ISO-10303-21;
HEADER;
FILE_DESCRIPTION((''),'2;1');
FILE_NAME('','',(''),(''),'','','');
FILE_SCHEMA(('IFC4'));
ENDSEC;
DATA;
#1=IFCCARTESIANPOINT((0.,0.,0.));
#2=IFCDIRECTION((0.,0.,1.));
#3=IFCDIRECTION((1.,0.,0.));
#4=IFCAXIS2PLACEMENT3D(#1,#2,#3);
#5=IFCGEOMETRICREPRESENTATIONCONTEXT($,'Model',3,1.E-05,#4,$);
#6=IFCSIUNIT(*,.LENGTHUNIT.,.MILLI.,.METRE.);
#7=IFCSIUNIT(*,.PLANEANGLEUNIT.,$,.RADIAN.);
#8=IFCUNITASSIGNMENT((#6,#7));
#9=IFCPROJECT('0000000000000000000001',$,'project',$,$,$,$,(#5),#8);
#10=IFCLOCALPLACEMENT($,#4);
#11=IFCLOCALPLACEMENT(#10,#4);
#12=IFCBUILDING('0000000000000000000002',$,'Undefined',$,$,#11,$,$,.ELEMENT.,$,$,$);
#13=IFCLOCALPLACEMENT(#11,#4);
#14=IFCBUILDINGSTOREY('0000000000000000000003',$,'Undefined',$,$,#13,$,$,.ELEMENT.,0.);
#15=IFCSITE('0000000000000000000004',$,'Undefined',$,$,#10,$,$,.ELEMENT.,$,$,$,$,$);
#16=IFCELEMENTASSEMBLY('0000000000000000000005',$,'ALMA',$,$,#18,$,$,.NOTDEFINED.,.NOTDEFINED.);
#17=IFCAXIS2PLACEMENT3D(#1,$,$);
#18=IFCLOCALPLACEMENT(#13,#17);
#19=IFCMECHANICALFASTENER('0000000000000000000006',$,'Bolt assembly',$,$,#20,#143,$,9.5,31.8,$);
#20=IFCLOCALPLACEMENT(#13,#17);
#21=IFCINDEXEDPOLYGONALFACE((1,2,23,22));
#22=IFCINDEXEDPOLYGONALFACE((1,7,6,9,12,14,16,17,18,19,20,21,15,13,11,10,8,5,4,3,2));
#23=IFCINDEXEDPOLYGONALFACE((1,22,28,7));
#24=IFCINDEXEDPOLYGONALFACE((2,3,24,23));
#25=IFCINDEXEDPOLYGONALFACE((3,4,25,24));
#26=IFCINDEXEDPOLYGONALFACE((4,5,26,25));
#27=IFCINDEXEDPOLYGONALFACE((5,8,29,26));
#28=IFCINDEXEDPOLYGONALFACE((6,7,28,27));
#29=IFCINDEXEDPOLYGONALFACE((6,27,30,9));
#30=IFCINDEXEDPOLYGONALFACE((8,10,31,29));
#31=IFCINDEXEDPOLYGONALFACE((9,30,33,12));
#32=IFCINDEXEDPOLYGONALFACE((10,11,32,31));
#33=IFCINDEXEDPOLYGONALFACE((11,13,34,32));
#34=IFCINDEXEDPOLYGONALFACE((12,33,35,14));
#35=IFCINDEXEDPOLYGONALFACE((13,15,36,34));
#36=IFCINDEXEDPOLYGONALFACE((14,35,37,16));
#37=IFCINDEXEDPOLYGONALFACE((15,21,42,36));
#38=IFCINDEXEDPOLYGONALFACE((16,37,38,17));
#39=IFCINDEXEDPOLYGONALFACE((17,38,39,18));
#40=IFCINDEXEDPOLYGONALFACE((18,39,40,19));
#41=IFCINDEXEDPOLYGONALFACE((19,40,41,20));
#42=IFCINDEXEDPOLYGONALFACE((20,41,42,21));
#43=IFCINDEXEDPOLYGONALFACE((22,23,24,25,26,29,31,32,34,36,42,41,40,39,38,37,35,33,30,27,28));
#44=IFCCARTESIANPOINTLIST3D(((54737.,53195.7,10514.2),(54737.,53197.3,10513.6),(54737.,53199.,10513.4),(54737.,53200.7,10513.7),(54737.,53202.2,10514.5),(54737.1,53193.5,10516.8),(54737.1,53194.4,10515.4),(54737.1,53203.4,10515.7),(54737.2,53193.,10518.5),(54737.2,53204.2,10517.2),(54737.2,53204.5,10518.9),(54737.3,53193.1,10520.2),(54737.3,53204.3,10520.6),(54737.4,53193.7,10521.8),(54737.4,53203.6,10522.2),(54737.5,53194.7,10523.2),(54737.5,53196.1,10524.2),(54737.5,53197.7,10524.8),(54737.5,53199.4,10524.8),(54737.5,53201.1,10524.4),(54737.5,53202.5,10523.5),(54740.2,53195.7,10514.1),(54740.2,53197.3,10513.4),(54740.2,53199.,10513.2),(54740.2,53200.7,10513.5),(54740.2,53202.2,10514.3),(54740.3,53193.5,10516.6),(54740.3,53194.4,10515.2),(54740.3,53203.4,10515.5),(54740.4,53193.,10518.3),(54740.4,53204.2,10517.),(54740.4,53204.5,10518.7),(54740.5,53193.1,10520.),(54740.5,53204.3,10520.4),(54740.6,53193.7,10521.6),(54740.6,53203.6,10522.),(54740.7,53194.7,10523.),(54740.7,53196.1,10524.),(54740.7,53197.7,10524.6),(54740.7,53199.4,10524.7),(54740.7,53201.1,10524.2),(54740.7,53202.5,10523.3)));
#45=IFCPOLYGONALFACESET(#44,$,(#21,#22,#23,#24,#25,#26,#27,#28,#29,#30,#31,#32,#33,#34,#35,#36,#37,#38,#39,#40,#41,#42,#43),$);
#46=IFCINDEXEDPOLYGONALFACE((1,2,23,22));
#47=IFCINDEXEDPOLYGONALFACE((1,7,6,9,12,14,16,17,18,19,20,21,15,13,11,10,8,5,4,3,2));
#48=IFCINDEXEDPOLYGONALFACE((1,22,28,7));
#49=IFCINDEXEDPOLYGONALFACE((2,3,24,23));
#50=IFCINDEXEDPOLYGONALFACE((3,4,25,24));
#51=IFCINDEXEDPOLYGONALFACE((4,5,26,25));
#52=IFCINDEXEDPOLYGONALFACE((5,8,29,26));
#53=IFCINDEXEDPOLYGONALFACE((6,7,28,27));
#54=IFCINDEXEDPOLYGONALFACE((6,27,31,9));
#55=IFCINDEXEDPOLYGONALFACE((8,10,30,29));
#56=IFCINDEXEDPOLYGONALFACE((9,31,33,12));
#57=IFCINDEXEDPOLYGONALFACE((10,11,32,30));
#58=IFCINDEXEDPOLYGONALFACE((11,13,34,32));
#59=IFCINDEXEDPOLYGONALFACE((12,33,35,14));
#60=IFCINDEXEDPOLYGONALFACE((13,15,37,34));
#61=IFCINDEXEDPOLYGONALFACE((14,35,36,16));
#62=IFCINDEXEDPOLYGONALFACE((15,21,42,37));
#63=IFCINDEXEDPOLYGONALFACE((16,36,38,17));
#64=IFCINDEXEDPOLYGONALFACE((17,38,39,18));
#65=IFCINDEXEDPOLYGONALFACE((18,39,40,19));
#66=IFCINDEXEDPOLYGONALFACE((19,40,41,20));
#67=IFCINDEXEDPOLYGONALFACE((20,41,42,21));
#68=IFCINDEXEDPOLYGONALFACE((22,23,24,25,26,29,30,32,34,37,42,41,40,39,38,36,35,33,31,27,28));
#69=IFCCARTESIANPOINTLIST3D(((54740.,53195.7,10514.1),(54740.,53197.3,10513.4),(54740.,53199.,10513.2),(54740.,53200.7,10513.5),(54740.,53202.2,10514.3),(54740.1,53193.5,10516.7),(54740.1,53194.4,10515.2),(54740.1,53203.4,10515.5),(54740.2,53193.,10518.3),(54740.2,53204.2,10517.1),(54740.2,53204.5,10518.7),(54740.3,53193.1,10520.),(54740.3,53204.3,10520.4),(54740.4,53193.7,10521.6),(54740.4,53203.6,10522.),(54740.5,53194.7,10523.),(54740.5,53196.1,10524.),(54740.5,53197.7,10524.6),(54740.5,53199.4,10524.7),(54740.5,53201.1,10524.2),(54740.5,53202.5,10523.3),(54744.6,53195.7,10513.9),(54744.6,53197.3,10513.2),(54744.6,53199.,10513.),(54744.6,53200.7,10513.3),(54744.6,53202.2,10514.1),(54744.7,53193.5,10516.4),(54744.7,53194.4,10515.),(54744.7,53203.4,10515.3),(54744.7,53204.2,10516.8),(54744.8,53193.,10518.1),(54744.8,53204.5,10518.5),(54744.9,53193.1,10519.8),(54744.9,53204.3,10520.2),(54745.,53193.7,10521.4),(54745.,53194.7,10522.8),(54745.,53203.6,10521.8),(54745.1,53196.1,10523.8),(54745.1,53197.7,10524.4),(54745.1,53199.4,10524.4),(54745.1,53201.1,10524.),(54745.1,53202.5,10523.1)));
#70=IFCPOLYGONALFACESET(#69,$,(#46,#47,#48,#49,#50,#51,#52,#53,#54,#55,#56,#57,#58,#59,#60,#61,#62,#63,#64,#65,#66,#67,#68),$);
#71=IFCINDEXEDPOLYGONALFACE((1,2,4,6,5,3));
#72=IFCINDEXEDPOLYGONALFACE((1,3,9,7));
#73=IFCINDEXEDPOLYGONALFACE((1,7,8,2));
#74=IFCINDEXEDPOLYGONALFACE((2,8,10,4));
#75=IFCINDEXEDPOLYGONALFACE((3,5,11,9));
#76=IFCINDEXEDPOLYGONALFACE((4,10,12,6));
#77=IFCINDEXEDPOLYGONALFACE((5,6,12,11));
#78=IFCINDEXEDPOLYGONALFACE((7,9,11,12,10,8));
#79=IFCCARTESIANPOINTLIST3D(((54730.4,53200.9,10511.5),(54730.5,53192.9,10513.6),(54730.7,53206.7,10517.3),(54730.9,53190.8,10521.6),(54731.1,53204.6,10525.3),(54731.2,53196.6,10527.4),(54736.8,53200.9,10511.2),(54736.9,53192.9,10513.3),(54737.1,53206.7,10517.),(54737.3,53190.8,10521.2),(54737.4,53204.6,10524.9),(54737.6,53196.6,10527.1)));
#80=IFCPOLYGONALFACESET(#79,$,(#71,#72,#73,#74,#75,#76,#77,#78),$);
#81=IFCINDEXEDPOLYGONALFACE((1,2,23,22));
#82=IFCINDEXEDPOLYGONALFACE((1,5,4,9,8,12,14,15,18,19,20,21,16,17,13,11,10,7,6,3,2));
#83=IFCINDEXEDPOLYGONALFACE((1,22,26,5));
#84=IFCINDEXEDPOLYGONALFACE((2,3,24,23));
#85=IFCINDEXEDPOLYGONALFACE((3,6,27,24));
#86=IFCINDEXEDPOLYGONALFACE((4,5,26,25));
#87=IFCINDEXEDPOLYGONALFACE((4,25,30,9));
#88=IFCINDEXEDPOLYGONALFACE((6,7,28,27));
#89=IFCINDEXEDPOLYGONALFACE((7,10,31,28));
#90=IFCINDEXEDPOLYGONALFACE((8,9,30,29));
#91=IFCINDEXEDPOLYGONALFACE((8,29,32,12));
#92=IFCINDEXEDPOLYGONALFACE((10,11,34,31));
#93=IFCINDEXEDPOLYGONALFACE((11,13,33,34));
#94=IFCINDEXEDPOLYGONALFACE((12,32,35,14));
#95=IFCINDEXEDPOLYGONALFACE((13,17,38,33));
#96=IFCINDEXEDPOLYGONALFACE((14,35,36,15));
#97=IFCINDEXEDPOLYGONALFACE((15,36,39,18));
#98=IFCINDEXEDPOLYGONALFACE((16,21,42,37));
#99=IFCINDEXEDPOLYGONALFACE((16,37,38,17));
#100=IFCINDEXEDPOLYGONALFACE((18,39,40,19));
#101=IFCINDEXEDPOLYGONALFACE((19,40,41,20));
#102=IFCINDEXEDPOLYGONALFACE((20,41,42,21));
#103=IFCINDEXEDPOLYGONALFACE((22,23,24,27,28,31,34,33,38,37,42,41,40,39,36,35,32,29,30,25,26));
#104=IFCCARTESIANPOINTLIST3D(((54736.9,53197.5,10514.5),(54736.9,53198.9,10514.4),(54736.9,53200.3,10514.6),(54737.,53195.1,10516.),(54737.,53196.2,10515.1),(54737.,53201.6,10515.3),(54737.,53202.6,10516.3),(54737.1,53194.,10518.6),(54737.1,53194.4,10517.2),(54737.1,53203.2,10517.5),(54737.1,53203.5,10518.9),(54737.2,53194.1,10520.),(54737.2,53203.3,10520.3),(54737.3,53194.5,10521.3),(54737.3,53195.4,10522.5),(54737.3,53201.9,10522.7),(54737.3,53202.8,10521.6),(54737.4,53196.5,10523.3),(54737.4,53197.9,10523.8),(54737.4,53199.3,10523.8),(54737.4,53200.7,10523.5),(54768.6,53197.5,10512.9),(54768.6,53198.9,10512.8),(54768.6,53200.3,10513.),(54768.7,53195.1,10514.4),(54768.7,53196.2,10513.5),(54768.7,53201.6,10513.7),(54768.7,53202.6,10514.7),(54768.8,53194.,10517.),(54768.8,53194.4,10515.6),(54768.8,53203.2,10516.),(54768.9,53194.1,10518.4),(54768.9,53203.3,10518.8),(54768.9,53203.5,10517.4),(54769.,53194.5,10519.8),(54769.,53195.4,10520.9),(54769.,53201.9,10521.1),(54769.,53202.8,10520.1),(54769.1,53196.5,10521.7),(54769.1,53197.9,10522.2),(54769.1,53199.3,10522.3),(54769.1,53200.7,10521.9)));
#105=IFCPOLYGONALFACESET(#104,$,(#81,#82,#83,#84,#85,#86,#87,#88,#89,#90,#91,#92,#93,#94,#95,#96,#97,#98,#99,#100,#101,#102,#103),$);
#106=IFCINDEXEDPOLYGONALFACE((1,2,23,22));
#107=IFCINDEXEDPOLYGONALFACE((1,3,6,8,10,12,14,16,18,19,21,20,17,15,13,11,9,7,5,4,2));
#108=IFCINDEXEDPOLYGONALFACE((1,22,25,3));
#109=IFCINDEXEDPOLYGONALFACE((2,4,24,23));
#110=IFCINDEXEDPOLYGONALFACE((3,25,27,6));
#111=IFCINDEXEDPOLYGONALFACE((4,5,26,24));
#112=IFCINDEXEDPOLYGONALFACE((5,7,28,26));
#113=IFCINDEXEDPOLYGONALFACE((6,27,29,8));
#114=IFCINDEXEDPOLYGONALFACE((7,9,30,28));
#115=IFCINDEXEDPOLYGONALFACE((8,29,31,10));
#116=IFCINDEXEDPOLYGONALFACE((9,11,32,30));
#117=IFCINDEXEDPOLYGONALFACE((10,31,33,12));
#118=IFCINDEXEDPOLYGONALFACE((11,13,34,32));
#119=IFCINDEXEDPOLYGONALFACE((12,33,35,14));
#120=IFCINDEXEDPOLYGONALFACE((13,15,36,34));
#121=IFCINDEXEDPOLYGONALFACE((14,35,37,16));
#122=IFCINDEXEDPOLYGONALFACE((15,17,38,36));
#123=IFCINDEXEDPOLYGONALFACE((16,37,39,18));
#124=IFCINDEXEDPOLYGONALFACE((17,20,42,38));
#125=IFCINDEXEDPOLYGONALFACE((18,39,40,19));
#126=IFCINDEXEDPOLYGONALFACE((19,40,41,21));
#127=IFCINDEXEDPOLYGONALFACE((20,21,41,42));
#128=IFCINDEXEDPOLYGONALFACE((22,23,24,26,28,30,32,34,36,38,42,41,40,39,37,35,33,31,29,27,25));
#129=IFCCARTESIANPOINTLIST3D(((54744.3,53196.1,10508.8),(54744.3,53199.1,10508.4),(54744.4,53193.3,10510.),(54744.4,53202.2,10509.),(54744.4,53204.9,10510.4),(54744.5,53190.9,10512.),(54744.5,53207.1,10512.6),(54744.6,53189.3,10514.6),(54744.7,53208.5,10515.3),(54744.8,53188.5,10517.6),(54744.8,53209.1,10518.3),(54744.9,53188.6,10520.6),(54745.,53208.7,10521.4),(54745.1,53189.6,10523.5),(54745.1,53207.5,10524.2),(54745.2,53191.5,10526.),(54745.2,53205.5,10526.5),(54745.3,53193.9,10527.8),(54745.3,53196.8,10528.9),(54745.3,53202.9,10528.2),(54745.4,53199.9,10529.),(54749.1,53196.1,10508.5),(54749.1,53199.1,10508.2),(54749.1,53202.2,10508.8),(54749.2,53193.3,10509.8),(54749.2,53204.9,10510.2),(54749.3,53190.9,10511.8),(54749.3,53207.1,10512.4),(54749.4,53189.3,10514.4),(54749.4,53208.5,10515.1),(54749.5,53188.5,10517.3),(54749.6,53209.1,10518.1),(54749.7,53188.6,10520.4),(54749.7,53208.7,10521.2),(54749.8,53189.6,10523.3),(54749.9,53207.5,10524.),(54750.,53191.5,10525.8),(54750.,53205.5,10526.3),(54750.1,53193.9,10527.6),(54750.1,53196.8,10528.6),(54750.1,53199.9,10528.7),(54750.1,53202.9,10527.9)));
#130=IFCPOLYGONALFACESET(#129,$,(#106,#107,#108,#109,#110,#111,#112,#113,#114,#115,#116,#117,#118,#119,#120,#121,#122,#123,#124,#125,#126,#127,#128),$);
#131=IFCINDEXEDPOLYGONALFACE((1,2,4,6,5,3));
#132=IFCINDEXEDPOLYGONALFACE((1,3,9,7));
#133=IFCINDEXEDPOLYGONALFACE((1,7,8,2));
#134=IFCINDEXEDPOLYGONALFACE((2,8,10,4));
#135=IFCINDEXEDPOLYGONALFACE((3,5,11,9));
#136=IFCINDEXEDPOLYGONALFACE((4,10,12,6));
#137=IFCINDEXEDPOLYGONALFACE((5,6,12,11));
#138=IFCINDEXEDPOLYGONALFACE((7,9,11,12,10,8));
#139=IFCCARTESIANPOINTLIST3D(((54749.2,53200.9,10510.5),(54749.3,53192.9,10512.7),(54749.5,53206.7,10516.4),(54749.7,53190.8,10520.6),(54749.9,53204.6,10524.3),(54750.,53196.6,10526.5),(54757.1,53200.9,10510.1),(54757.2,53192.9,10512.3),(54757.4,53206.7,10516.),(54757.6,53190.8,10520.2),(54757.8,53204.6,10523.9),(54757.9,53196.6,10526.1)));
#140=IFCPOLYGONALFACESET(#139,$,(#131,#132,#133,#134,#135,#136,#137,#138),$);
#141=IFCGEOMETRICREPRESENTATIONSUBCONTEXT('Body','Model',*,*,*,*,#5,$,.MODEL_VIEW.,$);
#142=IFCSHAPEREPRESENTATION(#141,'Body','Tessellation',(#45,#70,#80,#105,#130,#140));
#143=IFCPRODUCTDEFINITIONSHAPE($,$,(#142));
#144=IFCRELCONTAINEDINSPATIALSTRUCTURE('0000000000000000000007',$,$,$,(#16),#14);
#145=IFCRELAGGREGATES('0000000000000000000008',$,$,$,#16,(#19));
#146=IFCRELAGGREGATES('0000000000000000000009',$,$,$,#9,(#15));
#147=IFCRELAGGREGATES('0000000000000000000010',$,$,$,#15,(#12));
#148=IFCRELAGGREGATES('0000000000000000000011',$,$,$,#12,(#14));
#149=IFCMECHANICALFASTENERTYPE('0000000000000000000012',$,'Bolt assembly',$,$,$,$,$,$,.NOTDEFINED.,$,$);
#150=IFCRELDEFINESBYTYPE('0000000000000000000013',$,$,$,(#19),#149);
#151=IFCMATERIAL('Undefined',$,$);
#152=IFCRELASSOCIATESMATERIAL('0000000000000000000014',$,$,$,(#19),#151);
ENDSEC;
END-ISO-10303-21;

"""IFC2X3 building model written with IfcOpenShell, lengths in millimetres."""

from ifc_helpers import new_model, si_unit, frame, origin_with_axes, origin_2d_with_axis, place, context, subcontext, project, spatial, polyline, circle, outline, extrude, source, transform, mapped, material, type_object, element, aggregate, save


model = new_model("IFC2X3")

# Units and contexts
model_context = context("Model", 3, precision=1e-05, world=origin_with_axes())
body_context = subcontext(model_context, "Body", "Model", "MODEL_VIEW")
ifc_project = project(units=[si_unit("LENGTHUNIT", "METRE", prefix="MILLI"), si_unit("PLANEANGLEUNIT", "RADIAN")], contexts=[model_context])

# Site, building, storey
site_placement = place(None, origin_with_axes())
site = spatial("IfcSite", under=ifc_project, at=site_placement, Name="Undefined", CompositionType="ELEMENT")
building_placement = place(site_placement, origin_with_axes())
building = spatial("IfcBuilding", under=site, at=building_placement, Name="Undefined", CompositionType="ELEMENT")
storey_placement = place(building_placement, origin_with_axes())
storey = spatial("IfcBuildingStorey", under=building, at=storey_placement, Name="Undefined", CompositionType="ELEMENT", Elevation=0.0)

# Element assembly
assembly_1_placement = place(storey_placement, origin_with_axes())
assembly_1 = element("IfcElementAssembly", 1, at=assembly_1_placement, inside=storey, Name="ALMA", AssemblyPlace="NOTDEFINED", PredefinedType="NOTDEFINED")

# Shared definitions
ifc_material_1 = material(Name="Undefined")
mechanical_fastener_type = type_object("IfcMechanicalFastenerType", Name="Bolt assembly")

# Mechanical fastener
shared_shape_1 = source(origin_with_axes(), body_context, "Body", "SweptSolid", [
    extrude(circle(Radius=5.8, at=origin_2d_with_axis()), frame((0.0, -7.6, 0.0), z_axis=(0.0, 1.0, 0.0), x_axis=(1.0, 0.0, 0.0)), (0.0, 0.0, 1.0), 3.2),
    extrude(circle(Radius=5.8, at=origin_2d_with_axis()), frame((0.0, -4.6, 0.0), z_axis=(0.0, 1.0, 0.0), x_axis=(1.0, 0.0, 0.0)), (0.0, 0.0, 1.0), 4.6),
    extrude(outline(polyline([(7.1, -4.1), (7.1, 4.1), (0.0, 8.2), (-7.1, 4.1), (-7.1, -4.1), (0.0, -8.2), (7.1, -4.1)])), frame((0.0, -14.0, 0.0), z_axis=(0.0, 1.0, 0.0), x_axis=(1.0, 0.0, 0.0)), (0.0, 0.0, 1.0), 6.3),
    extrude(circle(Radius=4.8, at=origin_2d_with_axis()), frame((0.0, -7.7, 0.0), z_axis=(0.0, 1.0, 0.0), x_axis=(1.0, 0.0, 0.0)), (0.0, 0.0, 1.0), 31.8),
    extrude(circle(Radius=10.3, at=origin_2d_with_axis()), frame((0.0, 0.0, 0.0), z_axis=(0.0, 1.0, 0.0), x_axis=(1.0, 0.0, 0.0)), (0.0, 0.0, 1.0), 4.8),
    extrude(outline(polyline([(7.1, -4.1), (7.1, 4.1), (0.0, 8.2), (-7.1, 4.1), (-7.1, -4.1), (0.0, -8.2), (7.1, -4.1)])), frame((0.0, 4.8, 0.0), z_axis=(0.0, 1.0, 0.0), x_axis=(1.0, 0.0, 0.0)), (0.0, 0.0, 1.0), 7.9),
])
mechanical_fastener_1_placement = place(assembly_1_placement, frame((54744.8, 53198.8, 10518.7), z_axis=(0.035281, 0.707107, 0.706226), x_axis=(0.035282, -0.707107, 0.706226)))
mechanical_fastener_1 = element("IfcMechanicalFastener", 2, at=mechanical_fastener_1_placement, type_object=mechanical_fastener_type, material=ifc_material_1, Name="Bolt assembly", NominalDiameter=9.5, NominalLength=31.8, context=body_context, shape_type="MappedRepresentation", body=[
    mapped(shared_shape_1, transform((0.0, 0.0, 0.0))),
])
aggregate(assembly_1, [mechanical_fastener_1])

save(model, "model.ifc")
